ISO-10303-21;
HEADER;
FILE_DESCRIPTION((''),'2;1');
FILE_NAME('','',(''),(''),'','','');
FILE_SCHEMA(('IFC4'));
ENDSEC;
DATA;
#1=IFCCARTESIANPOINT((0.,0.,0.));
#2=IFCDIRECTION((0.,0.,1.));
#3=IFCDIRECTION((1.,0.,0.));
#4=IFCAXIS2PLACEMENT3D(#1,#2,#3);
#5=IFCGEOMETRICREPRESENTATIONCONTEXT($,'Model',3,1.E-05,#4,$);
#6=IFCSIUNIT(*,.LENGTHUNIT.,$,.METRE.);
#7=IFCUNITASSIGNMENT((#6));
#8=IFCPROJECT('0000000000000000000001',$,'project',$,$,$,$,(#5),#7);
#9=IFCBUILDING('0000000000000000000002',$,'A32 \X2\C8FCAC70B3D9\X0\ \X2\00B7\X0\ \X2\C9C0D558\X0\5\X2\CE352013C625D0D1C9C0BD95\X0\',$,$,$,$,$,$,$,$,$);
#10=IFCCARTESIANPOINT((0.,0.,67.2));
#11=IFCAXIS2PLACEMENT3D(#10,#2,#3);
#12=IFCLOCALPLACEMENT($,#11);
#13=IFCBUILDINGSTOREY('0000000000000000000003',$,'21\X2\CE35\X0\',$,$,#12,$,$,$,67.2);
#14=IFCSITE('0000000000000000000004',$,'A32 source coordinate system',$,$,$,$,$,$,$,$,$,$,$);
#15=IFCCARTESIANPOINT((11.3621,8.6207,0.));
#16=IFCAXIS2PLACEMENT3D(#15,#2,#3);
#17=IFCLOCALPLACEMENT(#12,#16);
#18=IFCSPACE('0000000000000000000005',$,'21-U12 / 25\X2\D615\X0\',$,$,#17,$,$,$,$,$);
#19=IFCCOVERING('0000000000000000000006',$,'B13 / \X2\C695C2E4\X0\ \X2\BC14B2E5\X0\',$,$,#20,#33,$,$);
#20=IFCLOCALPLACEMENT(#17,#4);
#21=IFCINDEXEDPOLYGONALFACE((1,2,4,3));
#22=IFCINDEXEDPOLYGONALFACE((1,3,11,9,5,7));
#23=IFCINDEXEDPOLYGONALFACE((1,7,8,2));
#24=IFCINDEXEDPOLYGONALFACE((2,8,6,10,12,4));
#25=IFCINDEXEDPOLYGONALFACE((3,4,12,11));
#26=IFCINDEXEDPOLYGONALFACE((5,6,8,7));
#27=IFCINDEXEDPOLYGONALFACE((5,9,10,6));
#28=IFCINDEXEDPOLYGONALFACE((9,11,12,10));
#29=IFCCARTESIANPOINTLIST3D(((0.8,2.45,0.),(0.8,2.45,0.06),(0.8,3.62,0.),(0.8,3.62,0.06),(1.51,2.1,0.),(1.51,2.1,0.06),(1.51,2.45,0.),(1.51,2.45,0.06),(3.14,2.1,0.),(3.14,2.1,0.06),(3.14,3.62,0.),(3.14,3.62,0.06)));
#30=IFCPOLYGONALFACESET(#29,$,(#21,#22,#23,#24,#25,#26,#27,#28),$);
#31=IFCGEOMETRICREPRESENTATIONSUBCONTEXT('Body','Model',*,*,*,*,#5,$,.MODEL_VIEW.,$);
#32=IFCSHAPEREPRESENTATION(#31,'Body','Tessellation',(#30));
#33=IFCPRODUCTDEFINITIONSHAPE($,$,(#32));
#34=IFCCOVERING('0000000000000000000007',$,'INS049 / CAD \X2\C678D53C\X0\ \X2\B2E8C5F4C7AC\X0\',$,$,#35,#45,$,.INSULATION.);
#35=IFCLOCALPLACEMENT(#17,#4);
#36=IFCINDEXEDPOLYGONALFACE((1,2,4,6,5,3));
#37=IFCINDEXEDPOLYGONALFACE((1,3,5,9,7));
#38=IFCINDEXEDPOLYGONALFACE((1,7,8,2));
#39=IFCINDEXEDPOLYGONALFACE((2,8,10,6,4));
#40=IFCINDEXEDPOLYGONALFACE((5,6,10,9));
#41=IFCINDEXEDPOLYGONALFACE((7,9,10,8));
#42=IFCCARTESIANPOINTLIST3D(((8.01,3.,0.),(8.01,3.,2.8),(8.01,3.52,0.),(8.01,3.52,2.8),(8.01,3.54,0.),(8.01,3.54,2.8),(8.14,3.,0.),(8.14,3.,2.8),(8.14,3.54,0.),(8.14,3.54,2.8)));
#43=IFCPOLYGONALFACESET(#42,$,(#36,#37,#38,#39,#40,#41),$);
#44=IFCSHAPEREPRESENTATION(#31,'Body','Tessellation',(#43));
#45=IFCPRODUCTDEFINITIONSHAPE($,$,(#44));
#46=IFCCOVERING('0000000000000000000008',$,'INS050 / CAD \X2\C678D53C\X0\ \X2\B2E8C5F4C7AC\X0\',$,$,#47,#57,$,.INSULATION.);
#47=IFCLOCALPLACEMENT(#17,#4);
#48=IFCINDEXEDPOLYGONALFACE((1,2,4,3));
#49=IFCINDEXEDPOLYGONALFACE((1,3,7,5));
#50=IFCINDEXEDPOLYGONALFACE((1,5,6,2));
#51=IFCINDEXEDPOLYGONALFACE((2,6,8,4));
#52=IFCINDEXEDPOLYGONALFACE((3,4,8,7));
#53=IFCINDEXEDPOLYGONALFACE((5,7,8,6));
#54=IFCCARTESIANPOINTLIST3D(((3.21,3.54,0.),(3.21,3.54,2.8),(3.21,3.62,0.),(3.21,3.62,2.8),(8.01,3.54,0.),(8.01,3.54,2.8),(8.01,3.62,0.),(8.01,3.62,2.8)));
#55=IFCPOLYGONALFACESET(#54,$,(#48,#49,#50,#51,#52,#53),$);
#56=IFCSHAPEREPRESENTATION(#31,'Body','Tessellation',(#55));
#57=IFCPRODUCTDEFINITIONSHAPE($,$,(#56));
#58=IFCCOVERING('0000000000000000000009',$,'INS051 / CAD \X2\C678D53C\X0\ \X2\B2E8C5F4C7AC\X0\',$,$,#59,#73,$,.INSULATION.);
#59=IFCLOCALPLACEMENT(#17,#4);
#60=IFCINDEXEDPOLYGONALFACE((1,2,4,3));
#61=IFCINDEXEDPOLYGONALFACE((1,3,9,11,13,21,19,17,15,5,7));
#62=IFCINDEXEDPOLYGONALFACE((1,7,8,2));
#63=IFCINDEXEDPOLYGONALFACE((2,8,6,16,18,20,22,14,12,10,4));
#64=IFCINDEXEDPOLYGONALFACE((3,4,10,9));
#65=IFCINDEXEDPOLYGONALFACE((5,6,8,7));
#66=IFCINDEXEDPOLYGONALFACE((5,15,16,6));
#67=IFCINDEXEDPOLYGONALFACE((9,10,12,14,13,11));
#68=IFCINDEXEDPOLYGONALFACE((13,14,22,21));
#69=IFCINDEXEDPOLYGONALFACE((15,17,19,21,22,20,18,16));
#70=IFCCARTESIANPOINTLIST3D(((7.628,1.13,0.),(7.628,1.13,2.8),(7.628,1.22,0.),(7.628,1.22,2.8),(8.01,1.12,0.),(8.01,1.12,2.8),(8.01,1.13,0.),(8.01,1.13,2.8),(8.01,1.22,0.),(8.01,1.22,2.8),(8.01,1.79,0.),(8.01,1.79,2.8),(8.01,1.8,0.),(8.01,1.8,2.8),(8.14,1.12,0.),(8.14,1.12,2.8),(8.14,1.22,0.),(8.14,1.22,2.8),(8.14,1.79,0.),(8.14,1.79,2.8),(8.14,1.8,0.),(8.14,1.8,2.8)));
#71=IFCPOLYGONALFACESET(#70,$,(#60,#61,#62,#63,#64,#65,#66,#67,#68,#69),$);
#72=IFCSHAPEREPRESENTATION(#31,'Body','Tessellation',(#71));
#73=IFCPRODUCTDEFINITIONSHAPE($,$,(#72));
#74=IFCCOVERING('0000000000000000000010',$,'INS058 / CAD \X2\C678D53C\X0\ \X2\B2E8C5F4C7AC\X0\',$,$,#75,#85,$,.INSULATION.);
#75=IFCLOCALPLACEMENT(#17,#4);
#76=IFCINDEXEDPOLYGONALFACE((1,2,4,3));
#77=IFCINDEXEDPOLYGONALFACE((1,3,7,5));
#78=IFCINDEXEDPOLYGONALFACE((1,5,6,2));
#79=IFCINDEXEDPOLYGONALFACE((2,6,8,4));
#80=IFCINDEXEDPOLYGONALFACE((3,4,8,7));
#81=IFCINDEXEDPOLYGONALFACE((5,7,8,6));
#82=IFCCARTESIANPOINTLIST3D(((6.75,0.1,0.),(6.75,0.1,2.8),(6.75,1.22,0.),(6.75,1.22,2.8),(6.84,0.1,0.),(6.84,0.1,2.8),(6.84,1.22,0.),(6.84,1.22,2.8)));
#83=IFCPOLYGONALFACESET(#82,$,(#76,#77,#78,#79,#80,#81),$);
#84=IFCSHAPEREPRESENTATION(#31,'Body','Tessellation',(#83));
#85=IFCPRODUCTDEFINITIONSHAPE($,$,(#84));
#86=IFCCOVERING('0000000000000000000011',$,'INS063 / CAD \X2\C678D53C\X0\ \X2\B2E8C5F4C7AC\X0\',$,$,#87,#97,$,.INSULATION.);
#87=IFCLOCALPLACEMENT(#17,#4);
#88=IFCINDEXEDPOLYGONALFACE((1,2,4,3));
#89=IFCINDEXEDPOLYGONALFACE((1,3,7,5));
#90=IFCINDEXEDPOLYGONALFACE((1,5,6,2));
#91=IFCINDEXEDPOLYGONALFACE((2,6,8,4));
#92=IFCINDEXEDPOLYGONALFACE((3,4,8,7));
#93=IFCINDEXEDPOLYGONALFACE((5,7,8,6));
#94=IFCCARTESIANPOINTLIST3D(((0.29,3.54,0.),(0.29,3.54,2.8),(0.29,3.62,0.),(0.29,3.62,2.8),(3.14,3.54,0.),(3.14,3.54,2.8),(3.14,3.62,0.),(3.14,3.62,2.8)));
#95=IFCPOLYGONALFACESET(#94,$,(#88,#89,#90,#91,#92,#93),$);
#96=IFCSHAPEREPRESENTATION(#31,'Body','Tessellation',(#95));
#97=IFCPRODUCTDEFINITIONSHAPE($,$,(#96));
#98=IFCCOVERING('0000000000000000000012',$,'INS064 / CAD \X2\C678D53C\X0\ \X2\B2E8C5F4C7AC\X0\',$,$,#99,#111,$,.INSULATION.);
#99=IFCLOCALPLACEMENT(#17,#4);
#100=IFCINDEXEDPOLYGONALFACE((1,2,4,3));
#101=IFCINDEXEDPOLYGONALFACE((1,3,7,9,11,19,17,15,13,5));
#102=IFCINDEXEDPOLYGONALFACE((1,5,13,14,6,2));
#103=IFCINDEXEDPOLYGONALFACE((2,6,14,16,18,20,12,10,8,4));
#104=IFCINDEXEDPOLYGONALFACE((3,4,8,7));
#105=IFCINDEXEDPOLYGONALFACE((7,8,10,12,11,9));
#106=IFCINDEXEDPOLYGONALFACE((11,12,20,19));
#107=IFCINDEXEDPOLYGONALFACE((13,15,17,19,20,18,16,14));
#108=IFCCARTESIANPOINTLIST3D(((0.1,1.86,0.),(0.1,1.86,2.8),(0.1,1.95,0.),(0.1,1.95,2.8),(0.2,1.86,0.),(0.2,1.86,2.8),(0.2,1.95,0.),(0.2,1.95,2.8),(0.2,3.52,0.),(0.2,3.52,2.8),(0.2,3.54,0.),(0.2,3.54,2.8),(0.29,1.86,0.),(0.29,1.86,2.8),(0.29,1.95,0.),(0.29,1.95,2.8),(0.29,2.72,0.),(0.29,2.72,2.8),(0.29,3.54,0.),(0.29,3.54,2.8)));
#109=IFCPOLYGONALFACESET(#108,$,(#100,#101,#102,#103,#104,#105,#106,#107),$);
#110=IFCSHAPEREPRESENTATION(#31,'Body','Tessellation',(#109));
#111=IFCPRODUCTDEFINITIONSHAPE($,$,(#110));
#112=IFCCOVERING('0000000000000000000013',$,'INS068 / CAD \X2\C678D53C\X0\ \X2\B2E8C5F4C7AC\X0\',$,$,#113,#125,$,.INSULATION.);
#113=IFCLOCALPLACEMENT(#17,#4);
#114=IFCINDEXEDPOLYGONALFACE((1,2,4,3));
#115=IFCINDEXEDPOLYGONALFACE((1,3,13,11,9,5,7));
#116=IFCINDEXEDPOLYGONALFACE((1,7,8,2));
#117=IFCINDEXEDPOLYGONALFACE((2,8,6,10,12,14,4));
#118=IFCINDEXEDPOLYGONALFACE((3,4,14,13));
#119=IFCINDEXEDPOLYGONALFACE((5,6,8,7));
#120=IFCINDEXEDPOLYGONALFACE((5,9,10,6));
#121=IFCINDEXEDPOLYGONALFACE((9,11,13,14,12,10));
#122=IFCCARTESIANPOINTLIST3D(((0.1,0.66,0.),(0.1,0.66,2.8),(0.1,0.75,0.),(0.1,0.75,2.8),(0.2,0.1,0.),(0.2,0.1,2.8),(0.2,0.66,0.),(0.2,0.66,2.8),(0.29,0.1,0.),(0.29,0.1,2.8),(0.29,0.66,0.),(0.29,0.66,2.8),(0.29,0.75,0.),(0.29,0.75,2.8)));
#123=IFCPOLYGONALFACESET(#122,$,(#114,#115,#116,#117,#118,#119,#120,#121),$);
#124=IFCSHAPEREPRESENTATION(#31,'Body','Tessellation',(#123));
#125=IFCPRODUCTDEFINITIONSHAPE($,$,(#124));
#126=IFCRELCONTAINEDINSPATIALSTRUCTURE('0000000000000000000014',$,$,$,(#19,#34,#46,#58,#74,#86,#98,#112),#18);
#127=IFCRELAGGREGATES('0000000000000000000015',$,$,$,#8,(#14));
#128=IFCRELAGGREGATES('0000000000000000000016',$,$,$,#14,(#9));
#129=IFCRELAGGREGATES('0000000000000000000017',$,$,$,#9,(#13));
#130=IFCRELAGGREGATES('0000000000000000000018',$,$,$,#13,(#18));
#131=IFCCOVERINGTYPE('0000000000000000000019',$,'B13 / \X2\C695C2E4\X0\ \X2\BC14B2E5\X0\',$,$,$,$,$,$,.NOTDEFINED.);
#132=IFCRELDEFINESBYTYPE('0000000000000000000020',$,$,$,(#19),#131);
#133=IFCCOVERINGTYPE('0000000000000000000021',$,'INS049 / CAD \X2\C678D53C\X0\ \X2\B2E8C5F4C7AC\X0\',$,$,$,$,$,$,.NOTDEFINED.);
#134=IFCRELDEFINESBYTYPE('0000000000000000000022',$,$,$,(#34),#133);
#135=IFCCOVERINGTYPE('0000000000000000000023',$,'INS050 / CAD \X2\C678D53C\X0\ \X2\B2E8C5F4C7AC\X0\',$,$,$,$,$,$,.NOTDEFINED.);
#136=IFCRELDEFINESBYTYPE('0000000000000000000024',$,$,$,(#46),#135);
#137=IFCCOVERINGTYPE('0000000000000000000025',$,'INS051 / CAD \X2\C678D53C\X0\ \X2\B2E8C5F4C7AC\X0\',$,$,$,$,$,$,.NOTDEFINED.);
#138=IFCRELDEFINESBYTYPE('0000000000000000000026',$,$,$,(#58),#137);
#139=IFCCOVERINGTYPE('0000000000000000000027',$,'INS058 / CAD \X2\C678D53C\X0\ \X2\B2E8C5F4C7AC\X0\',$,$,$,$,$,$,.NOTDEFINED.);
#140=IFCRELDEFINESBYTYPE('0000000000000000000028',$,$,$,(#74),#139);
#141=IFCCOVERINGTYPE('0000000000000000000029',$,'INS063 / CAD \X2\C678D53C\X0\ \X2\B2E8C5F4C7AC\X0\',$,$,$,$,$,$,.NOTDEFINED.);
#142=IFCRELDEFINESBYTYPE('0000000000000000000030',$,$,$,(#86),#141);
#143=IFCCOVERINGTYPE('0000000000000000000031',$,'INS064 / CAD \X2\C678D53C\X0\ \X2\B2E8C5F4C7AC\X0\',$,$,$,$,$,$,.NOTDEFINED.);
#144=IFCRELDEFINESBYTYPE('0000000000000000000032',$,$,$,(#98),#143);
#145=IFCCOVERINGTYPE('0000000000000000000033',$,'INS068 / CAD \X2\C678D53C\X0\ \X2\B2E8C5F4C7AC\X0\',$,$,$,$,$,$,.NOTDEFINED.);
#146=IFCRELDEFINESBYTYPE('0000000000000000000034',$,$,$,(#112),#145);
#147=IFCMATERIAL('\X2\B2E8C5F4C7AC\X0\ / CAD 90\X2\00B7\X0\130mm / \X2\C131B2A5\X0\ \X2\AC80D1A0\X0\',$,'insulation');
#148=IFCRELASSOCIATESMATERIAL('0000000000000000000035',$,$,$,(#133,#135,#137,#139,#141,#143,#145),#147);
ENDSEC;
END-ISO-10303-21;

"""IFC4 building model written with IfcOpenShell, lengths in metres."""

from ifc_helpers import new_model, si_unit, frame, origin, origin_with_axes, place, context, subcontext, project, spatial, polyline, outline, extrude, source, transform, mapped, material, type_object, type_shapes, element, save


model = new_model("IFC4")

# Units and contexts
model_context = context("Model", 3, precision=1e-05, world=origin_with_axes())
body_context = subcontext(model_context, "Body", "Model", "MODEL_VIEW")
ifc_project = project(units=[si_unit("LENGTHUNIT", "METRE")], contexts=[model_context])

# Site, building, storey
storey_placement = place(None, frame((0.0, 0.0, 67.2), z_axis=(0.0, 0.0, 1.0), x_axis=(1.0, 0.0, 0.0)))
space_1_placement = place(storey_placement, frame((11.3621, 8.6207, 0.0), z_axis=(0.0, 0.0, 1.0), x_axis=(1.0, 0.0, 0.0)))
site = spatial("IfcSite", under=ifc_project, Name="A32 source coordinate system")
building = spatial("IfcBuilding", under=site, Name="A32 주거동 · 지하5층–옥탑지붕")
storey = spatial("IfcBuildingStorey", under=building, at=storey_placement, Name="21층", Elevation=67.2)

# Shared definitions
space_1 = spatial("IfcSpace", under=storey, at=space_1_placement, Name="21-U12 / 25형")

# Coverings
covering_type_1 = type_object("IfcCoveringType", Name="B13 / 욕실 바닥", PredefinedType="NOTDEFINED")
shared_shape_1 = source(origin(), body_context, "Body", "SweptSolid", [
    extrude(outline(polyline([(3.14, 2.1), (1.51, 2.1), (1.51, 2.45), (0.8, 2.45), (0.8, 3.62), (3.14, 3.62), (3.14, 2.1)])), origin(), (0.0, 0.0, 1.0), 0.06),
])
type_shapes(covering_type_1, [shared_shape_1])
covering_1_placement = place(space_1_placement, origin_with_axes())
element("IfcCovering", 1, at=covering_1_placement, inside=space_1, type_object=covering_type_1, Name="B13 / 욕실 바닥", context=body_context, shape_type="MappedRepresentation", body=[
    mapped(shared_shape_1, transform((0.0, 0.0, 0.0), scale=1.0)),
])
ifc_material = material(Name="단열재 / CAD 90·130mm / 성능 검토", Category="insulation")
covering_type_2 = type_object("IfcCoveringType", Name="INS049 / CAD 외피 단열재", PredefinedType="NOTDEFINED", material=ifc_material)
shared_shape_2 = source(origin(), body_context, "Body", "SweptSolid", [
    extrude(outline(polyline([(8.01, 3.54), (8.14, 3.54), (8.14, 3.0), (8.01, 3.0), (8.01, 3.52), (8.01, 3.54)])), origin(), (0.0, 0.0, 1.0), 2.8),
])
type_shapes(covering_type_2, [shared_shape_2])
covering_2_placement = place(space_1_placement, origin_with_axes())
element("IfcCovering", 2, at=covering_2_placement, inside=space_1, type_object=covering_type_2, Name="INS049 / CAD 외피 단열재", PredefinedType="INSULATION", context=body_context, shape_type="MappedRepresentation", body=[
    mapped(shared_shape_2, transform((0.0, 0.0, 0.0), scale=1.0)),
])
covering_type_3 = type_object("IfcCoveringType", Name="INS050 / CAD 외피 단열재", PredefinedType="NOTDEFINED", material=ifc_material)
shared_shape_3 = source(origin(), body_context, "Body", "SweptSolid", [
    extrude(outline(polyline([(8.01, 3.54), (3.21, 3.54), (3.21, 3.62), (8.01, 3.62), (8.01, 3.54)])), origin(), (0.0, 0.0, 1.0), 2.8),
])
type_shapes(covering_type_3, [shared_shape_3])
covering_3_placement = place(space_1_placement, origin_with_axes())
element("IfcCovering", 3, at=covering_3_placement, inside=space_1, type_object=covering_type_3, Name="INS050 / CAD 외피 단열재", PredefinedType="INSULATION", context=body_context, shape_type="MappedRepresentation", body=[
    mapped(shared_shape_3, transform((0.0, 0.0, 0.0), scale=1.0)),
])
covering_type_4 = type_object("IfcCoveringType", Name="INS051 / CAD 외피 단열재", PredefinedType="NOTDEFINED", material=ifc_material)
shared_shape_4 = source(origin(), body_context, "Body", "SweptSolid", [
    extrude(outline(polyline([(8.14, 1.12), (8.01, 1.12), (8.01, 1.13), (7.628, 1.13), (7.628, 1.22), (8.01, 1.22), (8.01, 1.79), (8.01, 1.8), (8.14, 1.8), (8.14, 1.79), (8.14, 1.22), (8.14, 1.12)])), origin(), (0.0, 0.0, 1.0), 2.8),
])
type_shapes(covering_type_4, [shared_shape_4])
covering_4_placement = place(space_1_placement, origin_with_axes())
element("IfcCovering", 4, at=covering_4_placement, inside=space_1, type_object=covering_type_4, Name="INS051 / CAD 외피 단열재", PredefinedType="INSULATION", context=body_context, shape_type="MappedRepresentation", body=[
    mapped(shared_shape_4, transform((0.0, 0.0, 0.0), scale=1.0)),
])
covering_type_5 = type_object("IfcCoveringType", Name="INS058 / CAD 외피 단열재", PredefinedType="NOTDEFINED", material=ifc_material)
shared_shape_5 = source(origin(), body_context, "Body", "SweptSolid", [
    extrude(outline(polyline([(6.75, 0.1), (6.75, 1.22), (6.84, 1.22), (6.84, 0.1), (6.75, 0.1)])), origin(), (0.0, 0.0, 1.0), 2.8),
])
type_shapes(covering_type_5, [shared_shape_5])
covering_5_placement = place(space_1_placement, origin_with_axes())
element("IfcCovering", 5, at=covering_5_placement, inside=space_1, type_object=covering_type_5, Name="INS058 / CAD 외피 단열재", PredefinedType="INSULATION", context=body_context, shape_type="MappedRepresentation", body=[
    mapped(shared_shape_5, transform((0.0, 0.0, 0.0), scale=1.0)),
])
covering_type_6 = type_object("IfcCoveringType", Name="INS063 / CAD 외피 단열재", PredefinedType="NOTDEFINED", material=ifc_material)
shared_shape_6 = source(origin(), body_context, "Body", "SweptSolid", [
    extrude(outline(polyline([(0.29, 3.54), (0.29, 3.62), (3.14, 3.62), (3.14, 3.54), (0.29, 3.54)])), origin(), (0.0, 0.0, 1.0), 2.8),
])
type_shapes(covering_type_6, [shared_shape_6])
covering_6_placement = place(space_1_placement, origin_with_axes())
element("IfcCovering", 6, at=covering_6_placement, inside=space_1, type_object=covering_type_6, Name="INS063 / CAD 외피 단열재", PredefinedType="INSULATION", context=body_context, shape_type="MappedRepresentation", body=[
    mapped(shared_shape_6, transform((0.0, 0.0, 0.0), scale=1.0)),
])
covering_type_7 = type_object("IfcCoveringType", Name="INS064 / CAD 외피 단열재", PredefinedType="NOTDEFINED", material=ifc_material)
shared_shape_7 = source(origin(), body_context, "Body", "SweptSolid", [
    extrude(outline(polyline([(0.1, 1.86), (0.1, 1.95), (0.2, 1.95), (0.2, 3.52), (0.2, 3.54), (0.29, 3.54), (0.29, 2.72), (0.29, 1.95), (0.29, 1.86), (0.2, 1.86), (0.1, 1.86)])), origin(), (0.0, 0.0, 1.0), 2.8),
])
type_shapes(covering_type_7, [shared_shape_7])
covering_7_placement = place(space_1_placement, origin_with_axes())
element("IfcCovering", 7, at=covering_7_placement, inside=space_1, type_object=covering_type_7, Name="INS064 / CAD 외피 단열재", PredefinedType="INSULATION", context=body_context, shape_type="MappedRepresentation", body=[
    mapped(shared_shape_7, transform((0.0, 0.0, 0.0), scale=1.0)),
])
covering_type_8 = type_object("IfcCoveringType", Name="INS068 / CAD 외피 단열재", PredefinedType="NOTDEFINED", material=ifc_material)
shared_shape_8 = source(origin(), body_context, "Body", "SweptSolid", [
    extrude(outline(polyline([(0.2, 0.1), (0.2, 0.66), (0.1, 0.66), (0.1, 0.75), (0.29, 0.75), (0.29, 0.66), (0.29, 0.1), (0.2, 0.1)])), origin(), (0.0, 0.0, 1.0), 2.8),
])
type_shapes(covering_type_8, [shared_shape_8])
covering_8_placement = place(space_1_placement, origin_with_axes())
element("IfcCovering", 8, at=covering_8_placement, inside=space_1, type_object=covering_type_8, Name="INS068 / CAD 외피 단열재", PredefinedType="INSULATION", context=body_context, shape_type="MappedRepresentation", body=[
    mapped(shared_shape_8, transform((0.0, 0.0, 0.0), scale=1.0)),
])

save(model, "model.ifc")
